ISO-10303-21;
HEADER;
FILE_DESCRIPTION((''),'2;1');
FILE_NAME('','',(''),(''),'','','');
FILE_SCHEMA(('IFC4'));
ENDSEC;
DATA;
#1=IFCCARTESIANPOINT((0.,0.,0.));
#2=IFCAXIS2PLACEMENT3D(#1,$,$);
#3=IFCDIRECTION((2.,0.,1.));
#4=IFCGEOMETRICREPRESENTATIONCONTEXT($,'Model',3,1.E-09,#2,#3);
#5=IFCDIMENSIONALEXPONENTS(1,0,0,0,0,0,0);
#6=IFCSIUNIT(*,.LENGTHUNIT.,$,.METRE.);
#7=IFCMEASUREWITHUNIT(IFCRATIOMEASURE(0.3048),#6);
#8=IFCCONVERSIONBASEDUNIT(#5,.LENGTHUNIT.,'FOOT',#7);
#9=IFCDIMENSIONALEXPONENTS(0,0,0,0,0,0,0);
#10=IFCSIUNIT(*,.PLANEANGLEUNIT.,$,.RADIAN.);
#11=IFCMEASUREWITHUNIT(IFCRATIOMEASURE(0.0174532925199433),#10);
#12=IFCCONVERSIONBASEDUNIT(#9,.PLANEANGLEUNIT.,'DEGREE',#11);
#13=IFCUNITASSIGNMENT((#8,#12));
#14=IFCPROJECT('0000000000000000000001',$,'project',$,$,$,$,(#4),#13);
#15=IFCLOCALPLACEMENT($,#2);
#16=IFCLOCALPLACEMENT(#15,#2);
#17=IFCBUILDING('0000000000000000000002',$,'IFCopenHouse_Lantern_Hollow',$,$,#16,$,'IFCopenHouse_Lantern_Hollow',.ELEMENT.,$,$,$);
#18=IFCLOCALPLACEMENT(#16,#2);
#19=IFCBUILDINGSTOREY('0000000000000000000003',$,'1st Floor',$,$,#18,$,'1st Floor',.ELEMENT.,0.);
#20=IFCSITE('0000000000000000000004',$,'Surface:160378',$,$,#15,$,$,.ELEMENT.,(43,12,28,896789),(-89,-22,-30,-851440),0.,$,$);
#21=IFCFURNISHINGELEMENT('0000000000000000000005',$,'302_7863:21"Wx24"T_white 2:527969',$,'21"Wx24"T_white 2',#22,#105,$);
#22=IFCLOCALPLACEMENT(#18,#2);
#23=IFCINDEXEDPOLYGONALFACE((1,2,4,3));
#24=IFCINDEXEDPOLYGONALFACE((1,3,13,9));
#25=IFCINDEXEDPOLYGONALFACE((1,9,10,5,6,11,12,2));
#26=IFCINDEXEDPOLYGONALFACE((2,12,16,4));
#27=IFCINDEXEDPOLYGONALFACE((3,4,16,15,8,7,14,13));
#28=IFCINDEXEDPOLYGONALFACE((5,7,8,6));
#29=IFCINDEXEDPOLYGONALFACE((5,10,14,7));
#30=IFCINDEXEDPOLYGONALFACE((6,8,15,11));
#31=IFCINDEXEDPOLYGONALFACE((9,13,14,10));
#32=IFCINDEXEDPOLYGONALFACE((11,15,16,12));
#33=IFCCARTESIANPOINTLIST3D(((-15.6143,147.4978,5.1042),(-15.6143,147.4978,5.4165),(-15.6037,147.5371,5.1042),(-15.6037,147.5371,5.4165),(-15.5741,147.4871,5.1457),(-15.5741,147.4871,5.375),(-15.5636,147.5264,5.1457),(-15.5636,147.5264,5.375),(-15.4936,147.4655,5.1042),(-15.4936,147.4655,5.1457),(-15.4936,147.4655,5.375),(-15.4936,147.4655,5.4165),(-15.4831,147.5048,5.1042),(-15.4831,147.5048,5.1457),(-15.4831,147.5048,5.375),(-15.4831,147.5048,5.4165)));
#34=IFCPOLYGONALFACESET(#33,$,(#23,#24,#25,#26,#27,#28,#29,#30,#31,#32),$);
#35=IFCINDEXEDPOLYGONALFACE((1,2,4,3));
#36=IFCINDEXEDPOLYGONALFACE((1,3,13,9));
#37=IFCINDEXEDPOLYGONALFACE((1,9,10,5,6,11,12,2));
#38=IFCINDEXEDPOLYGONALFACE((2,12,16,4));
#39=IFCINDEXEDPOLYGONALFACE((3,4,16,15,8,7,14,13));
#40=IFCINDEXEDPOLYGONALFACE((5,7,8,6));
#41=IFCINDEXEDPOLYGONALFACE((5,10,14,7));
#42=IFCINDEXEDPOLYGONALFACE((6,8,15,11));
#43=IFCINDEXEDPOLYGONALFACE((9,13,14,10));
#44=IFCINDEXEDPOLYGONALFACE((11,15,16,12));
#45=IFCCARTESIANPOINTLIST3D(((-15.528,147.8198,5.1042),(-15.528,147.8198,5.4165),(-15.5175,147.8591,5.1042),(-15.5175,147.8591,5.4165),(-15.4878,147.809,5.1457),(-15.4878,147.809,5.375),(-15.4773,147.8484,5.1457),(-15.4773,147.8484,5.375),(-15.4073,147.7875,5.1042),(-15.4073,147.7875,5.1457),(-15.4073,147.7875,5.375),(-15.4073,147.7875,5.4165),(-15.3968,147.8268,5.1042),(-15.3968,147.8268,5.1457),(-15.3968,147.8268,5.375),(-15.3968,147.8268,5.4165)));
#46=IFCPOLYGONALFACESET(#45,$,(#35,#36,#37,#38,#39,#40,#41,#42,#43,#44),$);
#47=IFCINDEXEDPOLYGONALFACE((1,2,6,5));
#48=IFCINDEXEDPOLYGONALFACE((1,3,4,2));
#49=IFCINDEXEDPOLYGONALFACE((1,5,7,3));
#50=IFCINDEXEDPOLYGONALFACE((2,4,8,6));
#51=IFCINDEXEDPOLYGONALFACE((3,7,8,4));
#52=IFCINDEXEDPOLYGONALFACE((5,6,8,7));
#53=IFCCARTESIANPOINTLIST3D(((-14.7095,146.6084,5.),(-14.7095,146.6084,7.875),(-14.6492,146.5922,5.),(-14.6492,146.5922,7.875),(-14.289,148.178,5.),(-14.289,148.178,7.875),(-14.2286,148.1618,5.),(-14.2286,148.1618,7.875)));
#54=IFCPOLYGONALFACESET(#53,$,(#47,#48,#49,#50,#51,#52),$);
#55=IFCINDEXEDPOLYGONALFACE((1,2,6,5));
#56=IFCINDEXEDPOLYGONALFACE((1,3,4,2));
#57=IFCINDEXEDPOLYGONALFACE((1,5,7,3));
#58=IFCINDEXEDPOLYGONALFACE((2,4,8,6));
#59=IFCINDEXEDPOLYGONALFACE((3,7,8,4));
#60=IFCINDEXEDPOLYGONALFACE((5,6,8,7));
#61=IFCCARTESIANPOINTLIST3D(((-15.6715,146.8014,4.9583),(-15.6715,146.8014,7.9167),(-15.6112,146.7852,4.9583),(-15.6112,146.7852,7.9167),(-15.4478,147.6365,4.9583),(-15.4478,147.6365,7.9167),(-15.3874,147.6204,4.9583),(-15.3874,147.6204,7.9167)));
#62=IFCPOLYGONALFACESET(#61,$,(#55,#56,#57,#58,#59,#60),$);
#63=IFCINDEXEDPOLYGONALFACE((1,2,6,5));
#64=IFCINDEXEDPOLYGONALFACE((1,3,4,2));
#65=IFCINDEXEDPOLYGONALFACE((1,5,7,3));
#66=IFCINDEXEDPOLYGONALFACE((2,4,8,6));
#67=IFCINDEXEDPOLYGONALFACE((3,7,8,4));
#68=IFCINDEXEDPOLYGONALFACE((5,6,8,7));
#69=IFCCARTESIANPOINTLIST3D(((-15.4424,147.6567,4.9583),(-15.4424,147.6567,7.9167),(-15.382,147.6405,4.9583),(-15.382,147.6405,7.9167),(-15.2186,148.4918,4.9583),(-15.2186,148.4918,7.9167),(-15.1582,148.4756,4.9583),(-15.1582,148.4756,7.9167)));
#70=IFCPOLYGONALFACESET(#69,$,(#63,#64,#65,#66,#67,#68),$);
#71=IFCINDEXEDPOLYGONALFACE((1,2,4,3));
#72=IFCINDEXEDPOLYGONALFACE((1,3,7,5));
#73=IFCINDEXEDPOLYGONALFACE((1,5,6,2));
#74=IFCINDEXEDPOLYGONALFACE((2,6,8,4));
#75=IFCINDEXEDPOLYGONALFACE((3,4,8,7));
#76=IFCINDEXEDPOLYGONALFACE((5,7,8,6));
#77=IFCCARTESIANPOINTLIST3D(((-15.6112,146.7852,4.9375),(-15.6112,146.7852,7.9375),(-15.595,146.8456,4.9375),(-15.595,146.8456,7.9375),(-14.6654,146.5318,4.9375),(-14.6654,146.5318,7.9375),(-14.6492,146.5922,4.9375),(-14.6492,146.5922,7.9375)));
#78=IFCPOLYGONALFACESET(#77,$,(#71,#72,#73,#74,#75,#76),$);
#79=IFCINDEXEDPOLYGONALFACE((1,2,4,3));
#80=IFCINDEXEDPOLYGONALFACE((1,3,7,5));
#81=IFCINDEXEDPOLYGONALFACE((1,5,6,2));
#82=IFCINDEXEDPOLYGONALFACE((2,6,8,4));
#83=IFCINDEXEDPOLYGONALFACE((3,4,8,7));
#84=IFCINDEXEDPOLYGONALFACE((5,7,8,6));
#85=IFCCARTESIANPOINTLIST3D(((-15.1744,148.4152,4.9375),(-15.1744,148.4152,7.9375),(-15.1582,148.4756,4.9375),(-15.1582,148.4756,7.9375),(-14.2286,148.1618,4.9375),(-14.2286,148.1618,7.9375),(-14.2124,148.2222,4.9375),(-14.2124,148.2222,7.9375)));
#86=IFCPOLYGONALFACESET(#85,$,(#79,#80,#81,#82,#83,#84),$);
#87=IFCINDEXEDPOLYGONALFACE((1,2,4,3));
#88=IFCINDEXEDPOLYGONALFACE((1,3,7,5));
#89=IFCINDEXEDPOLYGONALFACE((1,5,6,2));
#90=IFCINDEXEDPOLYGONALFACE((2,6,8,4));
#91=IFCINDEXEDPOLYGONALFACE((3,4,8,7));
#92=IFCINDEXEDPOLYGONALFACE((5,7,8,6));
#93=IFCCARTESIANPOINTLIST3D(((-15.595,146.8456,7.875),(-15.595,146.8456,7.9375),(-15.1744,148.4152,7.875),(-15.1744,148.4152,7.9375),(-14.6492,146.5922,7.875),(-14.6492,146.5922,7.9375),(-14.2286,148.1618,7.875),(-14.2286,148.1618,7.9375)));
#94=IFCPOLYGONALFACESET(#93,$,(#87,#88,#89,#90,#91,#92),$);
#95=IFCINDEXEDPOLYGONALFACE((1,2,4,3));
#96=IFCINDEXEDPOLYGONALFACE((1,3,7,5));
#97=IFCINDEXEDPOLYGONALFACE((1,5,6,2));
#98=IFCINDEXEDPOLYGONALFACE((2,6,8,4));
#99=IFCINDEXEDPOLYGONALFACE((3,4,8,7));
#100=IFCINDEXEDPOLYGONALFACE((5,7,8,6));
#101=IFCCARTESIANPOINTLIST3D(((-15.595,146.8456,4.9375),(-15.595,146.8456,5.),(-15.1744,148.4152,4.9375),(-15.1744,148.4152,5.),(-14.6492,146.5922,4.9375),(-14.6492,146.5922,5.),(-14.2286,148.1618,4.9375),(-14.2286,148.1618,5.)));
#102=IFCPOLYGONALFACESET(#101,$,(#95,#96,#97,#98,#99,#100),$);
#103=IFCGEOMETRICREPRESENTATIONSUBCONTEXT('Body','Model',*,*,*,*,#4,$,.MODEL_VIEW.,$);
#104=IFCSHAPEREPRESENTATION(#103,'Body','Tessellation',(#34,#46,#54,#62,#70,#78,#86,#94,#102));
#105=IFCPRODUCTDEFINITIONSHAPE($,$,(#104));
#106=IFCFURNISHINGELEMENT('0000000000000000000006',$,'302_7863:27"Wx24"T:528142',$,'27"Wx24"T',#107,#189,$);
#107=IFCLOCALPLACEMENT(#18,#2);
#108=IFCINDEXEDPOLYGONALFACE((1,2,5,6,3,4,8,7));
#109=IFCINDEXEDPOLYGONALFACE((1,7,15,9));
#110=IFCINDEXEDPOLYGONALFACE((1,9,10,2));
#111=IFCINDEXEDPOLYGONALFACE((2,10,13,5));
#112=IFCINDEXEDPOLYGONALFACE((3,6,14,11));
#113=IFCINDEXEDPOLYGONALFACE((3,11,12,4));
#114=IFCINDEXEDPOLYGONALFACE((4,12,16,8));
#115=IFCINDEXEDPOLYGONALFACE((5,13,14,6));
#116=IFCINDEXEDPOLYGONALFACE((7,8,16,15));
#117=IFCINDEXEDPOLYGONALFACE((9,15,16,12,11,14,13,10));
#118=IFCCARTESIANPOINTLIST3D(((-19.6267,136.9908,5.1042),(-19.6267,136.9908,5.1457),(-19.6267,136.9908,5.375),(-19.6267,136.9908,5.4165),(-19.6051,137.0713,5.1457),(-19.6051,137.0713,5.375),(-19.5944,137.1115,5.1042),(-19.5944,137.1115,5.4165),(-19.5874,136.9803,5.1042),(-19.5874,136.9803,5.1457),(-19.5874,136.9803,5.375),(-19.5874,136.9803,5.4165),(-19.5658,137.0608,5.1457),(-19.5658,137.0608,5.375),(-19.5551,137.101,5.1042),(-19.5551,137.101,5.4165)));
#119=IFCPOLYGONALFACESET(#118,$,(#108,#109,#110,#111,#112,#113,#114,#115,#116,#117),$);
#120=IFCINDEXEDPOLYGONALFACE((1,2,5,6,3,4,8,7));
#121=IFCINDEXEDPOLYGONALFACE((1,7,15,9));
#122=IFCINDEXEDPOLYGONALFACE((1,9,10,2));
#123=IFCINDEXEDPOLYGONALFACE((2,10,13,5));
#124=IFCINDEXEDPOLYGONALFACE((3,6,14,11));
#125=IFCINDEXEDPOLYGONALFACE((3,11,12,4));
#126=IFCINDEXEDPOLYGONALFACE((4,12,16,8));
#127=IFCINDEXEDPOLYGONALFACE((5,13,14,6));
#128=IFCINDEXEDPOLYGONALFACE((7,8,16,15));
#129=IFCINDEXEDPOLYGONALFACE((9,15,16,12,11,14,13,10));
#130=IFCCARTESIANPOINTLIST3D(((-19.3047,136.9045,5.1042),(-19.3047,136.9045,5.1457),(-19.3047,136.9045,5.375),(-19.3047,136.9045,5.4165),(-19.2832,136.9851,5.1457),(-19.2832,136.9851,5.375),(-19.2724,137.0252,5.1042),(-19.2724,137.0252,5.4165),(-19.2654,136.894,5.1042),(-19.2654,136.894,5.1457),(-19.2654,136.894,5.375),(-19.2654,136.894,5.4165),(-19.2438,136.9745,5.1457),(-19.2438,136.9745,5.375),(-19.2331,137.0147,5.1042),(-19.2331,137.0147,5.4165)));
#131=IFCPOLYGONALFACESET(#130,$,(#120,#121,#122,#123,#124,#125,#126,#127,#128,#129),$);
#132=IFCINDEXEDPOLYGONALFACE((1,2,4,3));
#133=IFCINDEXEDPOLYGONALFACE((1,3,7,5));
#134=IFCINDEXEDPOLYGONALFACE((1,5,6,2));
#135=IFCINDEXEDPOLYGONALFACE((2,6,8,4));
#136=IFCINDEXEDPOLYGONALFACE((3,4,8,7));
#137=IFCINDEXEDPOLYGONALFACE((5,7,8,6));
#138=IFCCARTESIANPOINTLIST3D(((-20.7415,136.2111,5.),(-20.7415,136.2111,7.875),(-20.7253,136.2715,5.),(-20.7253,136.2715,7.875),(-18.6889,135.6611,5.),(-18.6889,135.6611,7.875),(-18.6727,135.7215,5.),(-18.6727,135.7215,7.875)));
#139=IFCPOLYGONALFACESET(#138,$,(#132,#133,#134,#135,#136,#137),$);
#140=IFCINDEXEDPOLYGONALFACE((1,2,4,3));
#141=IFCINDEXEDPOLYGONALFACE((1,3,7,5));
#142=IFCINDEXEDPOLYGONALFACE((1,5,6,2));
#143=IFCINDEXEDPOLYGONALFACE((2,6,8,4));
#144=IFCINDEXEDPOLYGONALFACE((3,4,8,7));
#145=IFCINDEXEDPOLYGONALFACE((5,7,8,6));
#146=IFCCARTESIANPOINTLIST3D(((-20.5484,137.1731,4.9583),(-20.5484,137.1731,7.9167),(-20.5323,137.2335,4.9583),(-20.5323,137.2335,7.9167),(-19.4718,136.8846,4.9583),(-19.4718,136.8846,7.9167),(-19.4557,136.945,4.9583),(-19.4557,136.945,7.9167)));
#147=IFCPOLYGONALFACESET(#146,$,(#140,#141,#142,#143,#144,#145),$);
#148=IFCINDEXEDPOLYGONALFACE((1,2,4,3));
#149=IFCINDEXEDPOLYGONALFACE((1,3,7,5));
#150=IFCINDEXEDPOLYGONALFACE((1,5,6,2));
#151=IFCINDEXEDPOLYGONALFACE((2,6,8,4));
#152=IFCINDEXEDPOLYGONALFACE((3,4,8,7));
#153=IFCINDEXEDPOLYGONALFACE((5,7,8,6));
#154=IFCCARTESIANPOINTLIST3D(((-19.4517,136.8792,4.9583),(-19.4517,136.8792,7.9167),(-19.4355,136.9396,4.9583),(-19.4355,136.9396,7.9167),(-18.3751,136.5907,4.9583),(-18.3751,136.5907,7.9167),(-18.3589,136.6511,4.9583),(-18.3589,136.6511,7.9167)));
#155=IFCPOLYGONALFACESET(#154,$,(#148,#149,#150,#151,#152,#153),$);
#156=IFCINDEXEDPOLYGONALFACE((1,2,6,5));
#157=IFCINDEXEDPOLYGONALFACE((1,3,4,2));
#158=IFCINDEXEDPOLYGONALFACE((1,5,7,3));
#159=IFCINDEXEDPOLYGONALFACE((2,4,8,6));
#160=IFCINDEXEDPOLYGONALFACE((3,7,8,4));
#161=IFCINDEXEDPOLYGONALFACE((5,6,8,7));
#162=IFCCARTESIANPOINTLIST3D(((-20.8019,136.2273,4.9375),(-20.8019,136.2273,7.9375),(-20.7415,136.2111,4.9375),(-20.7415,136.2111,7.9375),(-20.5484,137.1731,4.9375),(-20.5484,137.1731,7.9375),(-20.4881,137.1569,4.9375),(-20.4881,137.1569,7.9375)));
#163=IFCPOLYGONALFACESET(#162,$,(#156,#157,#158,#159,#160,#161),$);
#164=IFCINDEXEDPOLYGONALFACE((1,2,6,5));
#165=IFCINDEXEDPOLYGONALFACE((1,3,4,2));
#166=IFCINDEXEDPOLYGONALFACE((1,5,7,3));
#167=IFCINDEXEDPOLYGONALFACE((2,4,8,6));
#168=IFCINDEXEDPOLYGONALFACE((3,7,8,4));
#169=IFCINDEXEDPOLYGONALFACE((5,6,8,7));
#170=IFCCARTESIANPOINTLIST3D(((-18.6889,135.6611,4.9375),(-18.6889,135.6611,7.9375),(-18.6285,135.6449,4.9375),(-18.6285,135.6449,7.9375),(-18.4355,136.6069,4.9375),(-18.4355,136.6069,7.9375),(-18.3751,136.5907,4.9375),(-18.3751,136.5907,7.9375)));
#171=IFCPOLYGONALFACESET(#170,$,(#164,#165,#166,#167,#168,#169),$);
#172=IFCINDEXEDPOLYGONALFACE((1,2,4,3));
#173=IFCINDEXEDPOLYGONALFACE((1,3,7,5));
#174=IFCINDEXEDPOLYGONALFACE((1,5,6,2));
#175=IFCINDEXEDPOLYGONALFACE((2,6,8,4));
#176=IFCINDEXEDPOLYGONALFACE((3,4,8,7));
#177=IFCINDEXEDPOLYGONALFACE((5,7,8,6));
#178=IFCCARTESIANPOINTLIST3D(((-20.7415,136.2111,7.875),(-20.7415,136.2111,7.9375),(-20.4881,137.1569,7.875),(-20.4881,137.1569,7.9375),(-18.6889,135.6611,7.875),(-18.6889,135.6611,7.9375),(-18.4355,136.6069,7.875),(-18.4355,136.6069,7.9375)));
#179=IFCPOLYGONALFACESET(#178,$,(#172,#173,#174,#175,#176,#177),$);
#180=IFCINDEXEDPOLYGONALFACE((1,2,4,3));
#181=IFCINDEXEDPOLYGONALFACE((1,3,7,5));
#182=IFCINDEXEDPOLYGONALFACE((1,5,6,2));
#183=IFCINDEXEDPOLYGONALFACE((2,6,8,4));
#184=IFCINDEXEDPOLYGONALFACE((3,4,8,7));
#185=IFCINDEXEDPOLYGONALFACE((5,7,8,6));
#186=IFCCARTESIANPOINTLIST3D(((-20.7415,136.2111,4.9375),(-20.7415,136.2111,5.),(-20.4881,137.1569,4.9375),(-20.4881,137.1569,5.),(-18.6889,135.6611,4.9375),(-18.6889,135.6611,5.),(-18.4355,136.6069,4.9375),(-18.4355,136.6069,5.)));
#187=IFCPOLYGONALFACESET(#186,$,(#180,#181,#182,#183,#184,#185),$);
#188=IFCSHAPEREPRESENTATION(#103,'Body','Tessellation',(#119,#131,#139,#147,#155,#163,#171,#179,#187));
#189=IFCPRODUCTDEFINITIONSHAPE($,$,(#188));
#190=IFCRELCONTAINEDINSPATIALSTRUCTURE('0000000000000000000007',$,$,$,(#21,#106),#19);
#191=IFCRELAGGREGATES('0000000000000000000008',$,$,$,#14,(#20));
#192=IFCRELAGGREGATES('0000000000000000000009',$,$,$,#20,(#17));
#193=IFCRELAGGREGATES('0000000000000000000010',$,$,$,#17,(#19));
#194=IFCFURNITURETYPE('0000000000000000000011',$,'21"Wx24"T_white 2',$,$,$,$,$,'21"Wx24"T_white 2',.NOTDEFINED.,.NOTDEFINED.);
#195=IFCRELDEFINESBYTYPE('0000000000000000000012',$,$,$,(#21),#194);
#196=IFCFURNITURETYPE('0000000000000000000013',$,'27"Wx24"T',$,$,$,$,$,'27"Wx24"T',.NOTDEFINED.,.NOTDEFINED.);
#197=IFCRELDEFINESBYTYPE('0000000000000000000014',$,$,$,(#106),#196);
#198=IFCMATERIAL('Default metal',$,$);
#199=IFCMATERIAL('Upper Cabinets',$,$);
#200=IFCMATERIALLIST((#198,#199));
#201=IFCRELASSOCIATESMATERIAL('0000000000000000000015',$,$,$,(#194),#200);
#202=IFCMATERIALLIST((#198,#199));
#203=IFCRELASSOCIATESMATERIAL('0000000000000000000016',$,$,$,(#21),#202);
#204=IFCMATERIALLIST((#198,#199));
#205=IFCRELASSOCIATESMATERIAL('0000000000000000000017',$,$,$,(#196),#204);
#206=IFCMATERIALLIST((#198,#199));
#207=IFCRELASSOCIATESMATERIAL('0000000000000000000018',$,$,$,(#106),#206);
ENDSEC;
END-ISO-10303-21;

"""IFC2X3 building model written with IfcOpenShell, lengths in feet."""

from ifc_helpers import new_model, entity, si_unit, converted_unit, direction, frame, frame_2d, origin, origin_2d_with_axis, place, context, subcontext, project, spatial, polyline, rectangle, outline, extrude, source, transform, mapped, material, material_list, type_object, type_shapes, element, save


model = new_model("IFC2X3")

# Units and contexts
model_context = context("Model", 3, precision=1e-09, world=origin(), true_north=direction((2.0, 0.0, 1.0)))
body_context = subcontext(model_context, "Body", "Model", "MODEL_VIEW")
ifc_project = project(units=[converted_unit("LENGTHUNIT", "FOOT", entity("IfcRatioMeasure", 0.3048), si_unit("LENGTHUNIT", "METRE"), dimensions=[1, 0, 0, 0, 0, 0, 0]), converted_unit("PLANEANGLEUNIT", "DEGREE", entity("IfcRatioMeasure", 0.0174532925199433), si_unit("PLANEANGLEUNIT", "RADIAN"), dimensions=[0, 0, 0, 0, 0, 0, 0])], contexts=[model_context])

# Site, building, storey
site_placement = place(None, origin())
site = spatial("IfcSite", under=ifc_project, at=site_placement, Name="Surface:160378", CompositionType="ELEMENT", RefLatitude=(43, 12, 28, 896789), RefLongitude=(-89, -22, -30, -851440), RefElevation=0.0)
building_placement = place(site_placement, origin())
building = spatial("IfcBuilding", under=site, at=building_placement, Name="IFCopenHouse_Lantern_Hollow", LongName="IFCopenHouse_Lantern_Hollow", CompositionType="ELEMENT")
storey_placement = place(building_placement, origin())
storey = spatial("IfcBuildingStorey", under=building, at=storey_placement, Name="1st Floor", LongName="1st Floor", CompositionType="ELEMENT", Elevation=0.0)

# Furnishing elements
ifc_material_1 = material(Name="Default metal")
ifc_material_2 = material(Name="Upper Cabinets")
ifc_material_list_1 = material_list([ifc_material_1, ifc_material_2])
ifc_material_list_2 = material_list([ifc_material_1, ifc_material_2])
furniture_type_1 = type_object("IfcFurnitureType", Name="21\"Wx24\"T_white 2", ElementType="21\"Wx24\"T_white 2", AssemblyPlace="NOTDEFINED", material=ifc_material_list_2)
shared_shape_1 = source(origin(), body_context, "Body", "SweptSolid", [
    extrude(outline(polyline([(-0.0521, -0.1146), (-0.0521, -0.1562), (0.0729, -0.1562), (0.0729, 0.1562), (-0.0521, 0.1562), (-0.0521, 0.1146), (0.0313, 0.1146), (0.0313, -0.1146), (-0.0521, -0.1146)])), frame((0.6875, 1.0937, 0.3229), z_axis=(-1.0, 0.0, 0.0), x_axis=(0.0, 1.0, 0.0)), (0.0, 0.0, -1.0), 0.0407),
    extrude(outline(polyline([(-0.0521, -0.1146), (-0.0521, -0.1562), (0.0729, -0.1562), (0.0729, 0.1562), (-0.0521, 0.1562), (-0.0521, 0.1146), (0.0313, 0.1146), (0.0313, -0.1146), (-0.0521, -0.1146)])), frame((1.0208, 1.0937, 0.3229), z_axis=(-1.0, 0.0, 0.0), x_axis=(0.0, 1.0, 0.0)), (0.0, 0.0, -1.0), 0.0407),
    extrude(rectangle(XDim=0.0625, YDim=1.625, at=origin_2d_with_axis()), frame((0.875, 0.0313, 0.0625), z_axis=(0.0, 0.0, 1.0), x_axis=(0.0, 1.0, 0.0)), (0.0, 0.0, 1.0), 2.875),
    extrude(rectangle(XDim=0.0625, YDim=0.8646, at=frame_2d((0.0, 0.0), x_axis=(1.0, 0.0))), frame((0.4323, 1.0104, 0.0208), z_axis=(0.0, 0.0, 1.0), x_axis=(0.0, 1.0, 0.0)), (0.0, 0.0, 1.0), 2.9583),
    extrude(rectangle(XDim=0.0625, YDim=0.8646, at=frame_2d((0.0, 0.0), x_axis=(1.0, 0.0))), frame((1.3177, 1.0104, 0.0208), z_axis=(0.0, 0.0, 1.0), x_axis=(0.0, 1.0, 0.0)), (0.0, 0.0, 1.0), 2.9583),
    extrude(rectangle(XDim=0.0625, YDim=0.9792, at=frame_2d((0.0, 0.0), x_axis=(1.0, 0.0))), frame((0.0313, 0.4896, 0.0)), (0.0, 0.0, 1.0), 3.0),
    extrude(rectangle(XDim=0.0625, YDim=0.9792, at=frame_2d((0.0, 0.0), x_axis=(1.0, 0.0))), frame((1.7188, 0.4896, 0.0)), (0.0, 0.0, 1.0), 3.0),
    extrude(rectangle(XDim=1.625, YDim=0.9792, at=origin_2d_with_axis()), frame((0.875, 0.4896, 2.9375), z_axis=(0.0, 0.0, 1.0), x_axis=(-1.0, 0.0, 0.0)), (0.0, 0.0, 1.0), 0.0625),
    extrude(rectangle(XDim=1.625, YDim=0.9792, at=frame_2d((0.0, 0.0), x_axis=(1.0, 0.0))), frame((0.875, 0.4896, 0.0), z_axis=(0.0, 0.0, 1.0), x_axis=(-1.0, 0.0, 0.0)), (0.0, 0.0, 1.0), 0.0625),
])
type_shapes(furniture_type_1, [shared_shape_1])
furnishing_1_placement = place(storey_placement, frame((-14.6654, 146.5318, 4.9375), z_axis=(0.0, 0.0, 1.0), x_axis=(0.258819, 0.965926, 0.0)))
element("IfcFurnishingElement", 1, at=furnishing_1_placement, inside=storey, type_object=furniture_type_1, material=ifc_material_list_1, Name="302_7863:21\"Wx24\"T_white 2:527969", ObjectType="21\"Wx24\"T_white 2", context=body_context, shape_type="MappedRepresentation", body=[
    mapped(shared_shape_1, transform((0.0, 0.0, 0.0), scale=1.0)),
])
ifc_material_list_3 = material_list([ifc_material_1, ifc_material_2])
ifc_material_list_4 = material_list([ifc_material_1, ifc_material_2])
furniture_type_2 = type_object("IfcFurnitureType", Name="27\"Wx24\"T", ElementType="27\"Wx24\"T", AssemblyPlace="NOTDEFINED", material=ifc_material_list_4)
shared_shape_2 = source(origin(), body_context, "Body", "SweptSolid", [
    extrude(outline(polyline([(-0.0521, -0.1146), (-0.0521, -0.1562), (0.0729, -0.1562), (0.0729, 0.1562), (-0.0521, 0.1562), (-0.0521, 0.1146), (0.0313, 0.1146), (0.0313, -0.1146), (-0.0521, -0.1146)])), frame((0.9375, 1.0937, 0.3229), z_axis=(-1.0, 0.0, 0.0), x_axis=(0.0, 1.0, 0.0)), (0.0, 0.0, -1.0), 0.0407),
    extrude(outline(polyline([(-0.0521, -0.1146), (-0.0521, -0.1562), (0.0729, -0.1562), (0.0729, 0.1562), (-0.0521, 0.1562), (-0.0521, 0.1146), (0.0313, 0.1146), (0.0313, -0.1146), (-0.0521, -0.1146)])), frame((1.2708, 1.0937, 0.3229), z_axis=(-1.0, 0.0, 0.0), x_axis=(0.0, 1.0, 0.0)), (0.0, 0.0, -1.0), 0.0407),
    extrude(rectangle(XDim=0.0625, YDim=2.125, at=frame_2d((0.0, 0.0), x_axis=(1.0, 0.0))), frame((1.125, 0.0313, 0.0625), z_axis=(0.0, 0.0, 1.0), x_axis=(0.0, 1.0, 0.0)), (0.0, 0.0, 1.0), 2.875),
    extrude(rectangle(XDim=0.0625, YDim=1.1146, at=origin_2d_with_axis()), frame((0.5573, 1.0104, 0.0208), z_axis=(0.0, 0.0, 1.0), x_axis=(0.0, 1.0, 0.0)), (0.0, 0.0, 1.0), 2.9583),
    extrude(rectangle(XDim=0.0625, YDim=1.1146, at=frame_2d((0.0, 0.0), x_axis=(1.0, 0.0))), frame((1.6927, 1.0104, 0.0208), z_axis=(0.0, 0.0, 1.0), x_axis=(0.0, 1.0, 0.0)), (0.0, 0.0, 1.0), 2.9583),
    extrude(rectangle(XDim=0.0625, YDim=0.9792, at=frame_2d((0.0, 0.0), x_axis=(1.0, 0.0))), frame((0.0313, 0.4896, 0.0)), (0.0, 0.0, 1.0), 3.0),
    extrude(rectangle(XDim=0.0625, YDim=0.9792, at=origin_2d_with_axis()), frame((2.2188, 0.4896, 0.0)), (0.0, 0.0, 1.0), 3.0),
    extrude(rectangle(XDim=2.125, YDim=0.9792, at=origin_2d_with_axis()), frame((1.125, 0.4896, 2.9375), z_axis=(0.0, 0.0, 1.0), x_axis=(-1.0, 0.0, 0.0)), (0.0, 0.0, 1.0), 0.0625),
    extrude(rectangle(XDim=2.125, YDim=0.9792, at=frame_2d((0.0, 0.0), x_axis=(1.0, 0.0))), frame((1.125, 0.4896, 0.0), z_axis=(0.0, 0.0, 1.0), x_axis=(-1.0, 0.0, 0.0)), (0.0, 0.0, 1.0), 0.0625),
])
type_shapes(furniture_type_2, [shared_shape_2])
furnishing_2_placement = place(storey_placement, frame((-20.8019, 136.2273, 4.9375), z_axis=(0.0, 0.0, 1.0), x_axis=(0.965926, -0.258819, 0.0)))
element("IfcFurnishingElement", 2, at=furnishing_2_placement, inside=storey, type_object=furniture_type_2, material=ifc_material_list_3, Name="302_7863:27\"Wx24\"T:528142", ObjectType="27\"Wx24\"T", context=body_context, shape_type="MappedRepresentation", body=[
    mapped(shared_shape_2, transform((0.0, 0.0, 0.0), scale=1.0)),
])

save(model, "model.ifc")
